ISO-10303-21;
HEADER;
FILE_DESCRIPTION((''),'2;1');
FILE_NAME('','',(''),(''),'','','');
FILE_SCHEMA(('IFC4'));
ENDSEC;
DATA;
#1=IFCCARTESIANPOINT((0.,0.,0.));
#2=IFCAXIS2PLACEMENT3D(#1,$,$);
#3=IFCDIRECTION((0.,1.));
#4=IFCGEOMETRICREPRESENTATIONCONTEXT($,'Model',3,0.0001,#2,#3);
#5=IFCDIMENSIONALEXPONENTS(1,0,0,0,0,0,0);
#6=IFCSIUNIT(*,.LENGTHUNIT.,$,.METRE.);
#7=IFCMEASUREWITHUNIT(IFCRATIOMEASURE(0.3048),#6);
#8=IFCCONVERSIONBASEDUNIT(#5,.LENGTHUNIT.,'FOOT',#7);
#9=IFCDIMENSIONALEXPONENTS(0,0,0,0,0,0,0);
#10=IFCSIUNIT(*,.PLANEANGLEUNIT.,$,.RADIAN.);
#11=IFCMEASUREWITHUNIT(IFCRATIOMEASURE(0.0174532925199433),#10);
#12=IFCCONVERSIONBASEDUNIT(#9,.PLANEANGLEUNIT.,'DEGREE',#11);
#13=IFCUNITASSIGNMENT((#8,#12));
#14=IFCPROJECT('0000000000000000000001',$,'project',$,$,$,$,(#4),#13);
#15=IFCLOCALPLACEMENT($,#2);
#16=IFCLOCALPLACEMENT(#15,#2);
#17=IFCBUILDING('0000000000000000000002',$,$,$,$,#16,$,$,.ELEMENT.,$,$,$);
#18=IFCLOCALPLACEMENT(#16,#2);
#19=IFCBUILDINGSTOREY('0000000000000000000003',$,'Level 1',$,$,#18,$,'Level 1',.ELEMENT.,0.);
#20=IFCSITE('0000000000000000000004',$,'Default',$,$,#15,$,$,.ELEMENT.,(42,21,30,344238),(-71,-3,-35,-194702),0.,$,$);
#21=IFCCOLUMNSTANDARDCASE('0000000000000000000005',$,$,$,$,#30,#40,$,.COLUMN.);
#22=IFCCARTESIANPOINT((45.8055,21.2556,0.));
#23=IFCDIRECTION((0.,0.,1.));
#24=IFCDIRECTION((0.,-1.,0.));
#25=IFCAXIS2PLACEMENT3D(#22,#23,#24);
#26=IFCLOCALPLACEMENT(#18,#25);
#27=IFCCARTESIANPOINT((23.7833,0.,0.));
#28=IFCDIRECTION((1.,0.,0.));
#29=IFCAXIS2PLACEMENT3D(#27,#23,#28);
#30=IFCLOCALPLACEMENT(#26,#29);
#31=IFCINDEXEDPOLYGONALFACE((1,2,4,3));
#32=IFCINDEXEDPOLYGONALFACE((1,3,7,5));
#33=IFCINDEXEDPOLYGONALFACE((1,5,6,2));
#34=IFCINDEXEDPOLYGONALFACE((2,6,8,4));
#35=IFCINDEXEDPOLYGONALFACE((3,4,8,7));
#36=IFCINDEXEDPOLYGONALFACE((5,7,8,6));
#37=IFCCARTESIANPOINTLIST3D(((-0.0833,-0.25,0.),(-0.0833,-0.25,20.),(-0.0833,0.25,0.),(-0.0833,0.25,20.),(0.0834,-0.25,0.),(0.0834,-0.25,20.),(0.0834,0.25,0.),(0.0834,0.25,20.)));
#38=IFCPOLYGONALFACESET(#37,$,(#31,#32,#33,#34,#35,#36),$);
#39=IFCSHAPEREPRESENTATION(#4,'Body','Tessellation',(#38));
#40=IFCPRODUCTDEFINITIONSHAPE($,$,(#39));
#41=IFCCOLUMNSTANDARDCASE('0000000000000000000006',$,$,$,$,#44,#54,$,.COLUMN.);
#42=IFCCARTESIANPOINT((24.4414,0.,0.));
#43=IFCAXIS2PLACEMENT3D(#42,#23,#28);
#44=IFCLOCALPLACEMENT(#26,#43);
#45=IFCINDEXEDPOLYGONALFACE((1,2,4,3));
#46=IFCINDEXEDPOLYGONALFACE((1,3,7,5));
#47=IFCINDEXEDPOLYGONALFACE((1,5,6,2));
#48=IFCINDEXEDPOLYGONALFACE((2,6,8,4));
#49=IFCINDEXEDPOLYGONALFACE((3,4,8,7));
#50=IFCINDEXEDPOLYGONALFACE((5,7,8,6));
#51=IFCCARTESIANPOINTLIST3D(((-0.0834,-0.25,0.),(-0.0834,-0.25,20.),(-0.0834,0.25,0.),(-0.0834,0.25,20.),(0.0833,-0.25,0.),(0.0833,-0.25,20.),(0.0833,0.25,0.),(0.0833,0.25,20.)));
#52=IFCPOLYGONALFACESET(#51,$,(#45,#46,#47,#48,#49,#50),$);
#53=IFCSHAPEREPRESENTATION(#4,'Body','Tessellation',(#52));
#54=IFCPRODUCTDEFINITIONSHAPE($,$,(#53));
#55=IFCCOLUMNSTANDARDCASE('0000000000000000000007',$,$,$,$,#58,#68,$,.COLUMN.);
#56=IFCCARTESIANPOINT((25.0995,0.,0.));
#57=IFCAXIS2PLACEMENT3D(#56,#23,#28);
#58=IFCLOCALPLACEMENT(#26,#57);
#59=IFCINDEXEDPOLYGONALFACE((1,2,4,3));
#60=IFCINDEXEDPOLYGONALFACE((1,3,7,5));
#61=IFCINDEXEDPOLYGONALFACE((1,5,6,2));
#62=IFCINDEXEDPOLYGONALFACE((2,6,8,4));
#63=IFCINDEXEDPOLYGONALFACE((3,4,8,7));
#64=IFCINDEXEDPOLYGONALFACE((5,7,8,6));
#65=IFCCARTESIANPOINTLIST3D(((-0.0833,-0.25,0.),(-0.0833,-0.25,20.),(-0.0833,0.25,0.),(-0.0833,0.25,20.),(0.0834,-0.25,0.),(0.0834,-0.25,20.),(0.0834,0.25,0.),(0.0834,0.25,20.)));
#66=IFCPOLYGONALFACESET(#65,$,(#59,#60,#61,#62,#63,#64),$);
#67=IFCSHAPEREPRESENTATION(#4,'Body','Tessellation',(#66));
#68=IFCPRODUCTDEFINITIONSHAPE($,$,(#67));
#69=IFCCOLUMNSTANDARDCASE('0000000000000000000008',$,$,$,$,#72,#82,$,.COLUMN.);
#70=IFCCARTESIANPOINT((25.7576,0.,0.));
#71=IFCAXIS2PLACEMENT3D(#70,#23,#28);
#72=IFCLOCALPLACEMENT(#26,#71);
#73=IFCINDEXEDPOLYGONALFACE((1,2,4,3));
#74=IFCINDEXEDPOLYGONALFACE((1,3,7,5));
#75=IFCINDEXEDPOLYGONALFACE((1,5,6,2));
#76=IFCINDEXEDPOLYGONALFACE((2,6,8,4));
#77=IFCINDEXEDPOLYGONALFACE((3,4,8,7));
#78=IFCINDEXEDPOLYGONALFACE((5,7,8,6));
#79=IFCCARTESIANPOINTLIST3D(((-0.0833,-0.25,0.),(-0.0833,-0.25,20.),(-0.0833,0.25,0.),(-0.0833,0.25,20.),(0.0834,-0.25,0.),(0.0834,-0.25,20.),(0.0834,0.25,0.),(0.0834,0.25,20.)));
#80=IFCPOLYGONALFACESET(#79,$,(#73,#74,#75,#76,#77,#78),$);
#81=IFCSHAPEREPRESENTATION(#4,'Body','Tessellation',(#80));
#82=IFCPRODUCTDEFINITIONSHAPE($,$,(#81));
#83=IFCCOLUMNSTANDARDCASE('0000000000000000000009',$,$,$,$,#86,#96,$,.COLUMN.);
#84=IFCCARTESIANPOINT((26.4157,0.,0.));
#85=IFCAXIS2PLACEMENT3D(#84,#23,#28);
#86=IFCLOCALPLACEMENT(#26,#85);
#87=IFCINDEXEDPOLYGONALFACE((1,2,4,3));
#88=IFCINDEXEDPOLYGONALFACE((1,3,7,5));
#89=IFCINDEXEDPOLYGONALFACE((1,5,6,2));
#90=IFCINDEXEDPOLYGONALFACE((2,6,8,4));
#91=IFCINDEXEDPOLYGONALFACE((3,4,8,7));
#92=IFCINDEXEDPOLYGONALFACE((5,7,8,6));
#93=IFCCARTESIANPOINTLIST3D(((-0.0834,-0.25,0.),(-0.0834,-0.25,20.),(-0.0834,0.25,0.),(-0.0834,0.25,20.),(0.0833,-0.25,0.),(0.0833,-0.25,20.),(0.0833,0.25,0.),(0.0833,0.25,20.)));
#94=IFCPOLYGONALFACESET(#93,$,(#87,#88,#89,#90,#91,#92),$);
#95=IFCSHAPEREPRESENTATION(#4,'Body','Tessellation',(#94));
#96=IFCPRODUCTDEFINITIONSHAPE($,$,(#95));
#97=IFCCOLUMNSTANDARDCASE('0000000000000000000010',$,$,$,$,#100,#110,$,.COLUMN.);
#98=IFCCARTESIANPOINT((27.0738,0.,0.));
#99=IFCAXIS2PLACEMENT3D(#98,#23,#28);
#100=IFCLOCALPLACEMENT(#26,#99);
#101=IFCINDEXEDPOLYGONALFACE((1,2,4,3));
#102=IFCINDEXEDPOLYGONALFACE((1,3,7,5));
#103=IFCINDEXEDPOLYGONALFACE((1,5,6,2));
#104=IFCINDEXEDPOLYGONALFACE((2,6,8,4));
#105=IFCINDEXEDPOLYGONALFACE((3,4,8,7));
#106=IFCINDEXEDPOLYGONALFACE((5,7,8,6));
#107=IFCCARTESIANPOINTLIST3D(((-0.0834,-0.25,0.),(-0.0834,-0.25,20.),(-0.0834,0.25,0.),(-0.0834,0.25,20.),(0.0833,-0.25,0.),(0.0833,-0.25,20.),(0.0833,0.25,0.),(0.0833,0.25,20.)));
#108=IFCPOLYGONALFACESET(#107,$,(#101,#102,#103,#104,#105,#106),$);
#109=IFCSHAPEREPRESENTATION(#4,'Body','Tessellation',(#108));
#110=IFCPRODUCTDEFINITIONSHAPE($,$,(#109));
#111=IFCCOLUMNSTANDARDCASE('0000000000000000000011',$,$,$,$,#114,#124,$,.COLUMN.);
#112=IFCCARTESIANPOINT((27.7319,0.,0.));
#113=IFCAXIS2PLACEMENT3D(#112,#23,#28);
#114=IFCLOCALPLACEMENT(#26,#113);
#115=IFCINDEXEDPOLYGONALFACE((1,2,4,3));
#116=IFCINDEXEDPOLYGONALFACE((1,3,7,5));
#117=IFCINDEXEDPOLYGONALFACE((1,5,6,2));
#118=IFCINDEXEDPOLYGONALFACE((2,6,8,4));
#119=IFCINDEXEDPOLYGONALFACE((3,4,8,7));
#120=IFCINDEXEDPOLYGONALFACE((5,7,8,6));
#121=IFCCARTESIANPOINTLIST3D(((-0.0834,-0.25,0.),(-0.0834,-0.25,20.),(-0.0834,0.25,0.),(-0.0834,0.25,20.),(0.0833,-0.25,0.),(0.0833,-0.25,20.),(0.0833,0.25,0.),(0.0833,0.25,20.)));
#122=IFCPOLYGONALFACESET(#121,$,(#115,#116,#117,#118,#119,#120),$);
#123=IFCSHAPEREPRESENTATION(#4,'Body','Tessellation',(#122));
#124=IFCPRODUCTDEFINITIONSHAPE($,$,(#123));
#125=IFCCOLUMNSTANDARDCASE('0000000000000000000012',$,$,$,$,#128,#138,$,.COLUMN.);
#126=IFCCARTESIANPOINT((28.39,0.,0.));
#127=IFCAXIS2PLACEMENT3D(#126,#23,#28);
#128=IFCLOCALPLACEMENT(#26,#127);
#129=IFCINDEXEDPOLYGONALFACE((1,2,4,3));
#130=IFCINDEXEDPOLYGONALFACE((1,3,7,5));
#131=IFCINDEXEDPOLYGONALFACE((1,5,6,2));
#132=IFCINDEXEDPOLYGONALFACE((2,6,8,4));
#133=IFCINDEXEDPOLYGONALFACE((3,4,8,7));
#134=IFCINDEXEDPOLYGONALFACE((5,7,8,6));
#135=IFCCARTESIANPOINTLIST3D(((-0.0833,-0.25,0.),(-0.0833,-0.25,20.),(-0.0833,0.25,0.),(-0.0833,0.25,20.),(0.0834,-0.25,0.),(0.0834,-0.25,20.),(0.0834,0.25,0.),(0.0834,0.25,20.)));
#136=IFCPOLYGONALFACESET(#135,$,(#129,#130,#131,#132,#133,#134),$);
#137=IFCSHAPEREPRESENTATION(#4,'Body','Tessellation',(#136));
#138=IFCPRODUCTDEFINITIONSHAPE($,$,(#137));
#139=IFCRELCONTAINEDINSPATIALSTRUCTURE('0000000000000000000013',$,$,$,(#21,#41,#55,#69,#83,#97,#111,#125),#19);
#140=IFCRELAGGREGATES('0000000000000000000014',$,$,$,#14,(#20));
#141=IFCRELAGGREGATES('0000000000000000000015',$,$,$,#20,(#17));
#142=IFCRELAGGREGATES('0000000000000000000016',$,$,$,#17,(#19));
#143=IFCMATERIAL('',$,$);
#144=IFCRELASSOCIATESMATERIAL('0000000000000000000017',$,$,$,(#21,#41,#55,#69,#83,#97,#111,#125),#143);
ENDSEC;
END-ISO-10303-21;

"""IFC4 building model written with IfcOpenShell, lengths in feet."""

from ifc_helpers import new_model, entity, si_unit, converted_unit, direction, frame, origin, place, context, project, spatial, rectangle, extrude, material, element, save


model = new_model("IFC4")

# Units and contexts
model_context = context("Model", 3, precision=0.0001, world=origin(), true_north=direction((0.0, 1.0)))
ifc_project = project(units=[converted_unit("LENGTHUNIT", "FOOT", entity("IfcRatioMeasure", 0.3048), si_unit("LENGTHUNIT", "METRE"), dimensions=[1, 0, 0, 0, 0, 0, 0]), converted_unit("PLANEANGLEUNIT", "DEGREE", entity("IfcRatioMeasure", 0.0174532925199433), si_unit("PLANEANGLEUNIT", "RADIAN"), dimensions=[0, 0, 0, 0, 0, 0, 0])], contexts=[model_context])

# Site, building, storey
site_placement = place(None, origin())
site = spatial("IfcSite", under=ifc_project, at=site_placement, Name="Default", CompositionType="ELEMENT", RefLatitude=(42, 21, 30, 344238), RefLongitude=(-71, -3, -35, -194702), RefElevation=0.0)
building_placement = place(site_placement, origin())
building = spatial("IfcBuilding", under=site, at=building_placement, CompositionType="ELEMENT")
storey_placement = place(building_placement, origin())
storey = spatial("IfcBuildingStorey", under=building, at=storey_placement, Name="Level 1", LongName="Level 1", CompositionType="ELEMENT", Elevation=0.0)

# Columns
ifc_material_1 = material(Name="")
placement = place(storey_placement, frame((45.8055, 21.2556, 0.0), z_axis=(0.0, 0.0, 1.0), x_axis=(0.0, -1.0, 0.0)))
for number, where, z_axis, x_axis in (
    (1, (23.7833, 0.0, 0.0), (0.0, 0.0, 1.0), (1.0, 0.0, 0.0)),
    (2, (24.4414, 0.0, 0.0), (0.0, 0.0, 1.0), (1.0, 0.0, 0.0)),
    (3, (25.0995, 0.0, 0.0), (0.0, 0.0, 1.0), (1.0, 0.0, 0.0)),
    (4, (25.7576, 0.0, 0.0), (0.0, 0.0, 1.0), (1.0, 0.0, 0.0)),
    (5, (26.4157, 0.0, 0.0), (0.0, 0.0, 1.0), (1.0, 0.0, 0.0)),
    (6, (27.0738, 0.0, 0.0), (0.0, 0.0, 1.0), (1.0, 0.0, 0.0)),
    (7, (27.7319, 0.0, 0.0), (0.0, 0.0, 1.0), (1.0, 0.0, 0.0)),
    (8, (28.39, 0.0, 0.0), (0.0, 0.0, 1.0), (1.0, 0.0, 0.0)),
):
    element("IfcColumnStandardCase", number, at=place(placement, frame(where, z_axis=z_axis, x_axis=x_axis)), inside=storey, material=ifc_material_1, PredefinedType="COLUMN", context=model_context, shape_type="SweptSolid", body=[
        extrude(rectangle(XDim=0.1667, YDim=0.5), origin(), (0.0, 0.0, 1.0), 20.0),
    ])

save(model, "model.ifc")
